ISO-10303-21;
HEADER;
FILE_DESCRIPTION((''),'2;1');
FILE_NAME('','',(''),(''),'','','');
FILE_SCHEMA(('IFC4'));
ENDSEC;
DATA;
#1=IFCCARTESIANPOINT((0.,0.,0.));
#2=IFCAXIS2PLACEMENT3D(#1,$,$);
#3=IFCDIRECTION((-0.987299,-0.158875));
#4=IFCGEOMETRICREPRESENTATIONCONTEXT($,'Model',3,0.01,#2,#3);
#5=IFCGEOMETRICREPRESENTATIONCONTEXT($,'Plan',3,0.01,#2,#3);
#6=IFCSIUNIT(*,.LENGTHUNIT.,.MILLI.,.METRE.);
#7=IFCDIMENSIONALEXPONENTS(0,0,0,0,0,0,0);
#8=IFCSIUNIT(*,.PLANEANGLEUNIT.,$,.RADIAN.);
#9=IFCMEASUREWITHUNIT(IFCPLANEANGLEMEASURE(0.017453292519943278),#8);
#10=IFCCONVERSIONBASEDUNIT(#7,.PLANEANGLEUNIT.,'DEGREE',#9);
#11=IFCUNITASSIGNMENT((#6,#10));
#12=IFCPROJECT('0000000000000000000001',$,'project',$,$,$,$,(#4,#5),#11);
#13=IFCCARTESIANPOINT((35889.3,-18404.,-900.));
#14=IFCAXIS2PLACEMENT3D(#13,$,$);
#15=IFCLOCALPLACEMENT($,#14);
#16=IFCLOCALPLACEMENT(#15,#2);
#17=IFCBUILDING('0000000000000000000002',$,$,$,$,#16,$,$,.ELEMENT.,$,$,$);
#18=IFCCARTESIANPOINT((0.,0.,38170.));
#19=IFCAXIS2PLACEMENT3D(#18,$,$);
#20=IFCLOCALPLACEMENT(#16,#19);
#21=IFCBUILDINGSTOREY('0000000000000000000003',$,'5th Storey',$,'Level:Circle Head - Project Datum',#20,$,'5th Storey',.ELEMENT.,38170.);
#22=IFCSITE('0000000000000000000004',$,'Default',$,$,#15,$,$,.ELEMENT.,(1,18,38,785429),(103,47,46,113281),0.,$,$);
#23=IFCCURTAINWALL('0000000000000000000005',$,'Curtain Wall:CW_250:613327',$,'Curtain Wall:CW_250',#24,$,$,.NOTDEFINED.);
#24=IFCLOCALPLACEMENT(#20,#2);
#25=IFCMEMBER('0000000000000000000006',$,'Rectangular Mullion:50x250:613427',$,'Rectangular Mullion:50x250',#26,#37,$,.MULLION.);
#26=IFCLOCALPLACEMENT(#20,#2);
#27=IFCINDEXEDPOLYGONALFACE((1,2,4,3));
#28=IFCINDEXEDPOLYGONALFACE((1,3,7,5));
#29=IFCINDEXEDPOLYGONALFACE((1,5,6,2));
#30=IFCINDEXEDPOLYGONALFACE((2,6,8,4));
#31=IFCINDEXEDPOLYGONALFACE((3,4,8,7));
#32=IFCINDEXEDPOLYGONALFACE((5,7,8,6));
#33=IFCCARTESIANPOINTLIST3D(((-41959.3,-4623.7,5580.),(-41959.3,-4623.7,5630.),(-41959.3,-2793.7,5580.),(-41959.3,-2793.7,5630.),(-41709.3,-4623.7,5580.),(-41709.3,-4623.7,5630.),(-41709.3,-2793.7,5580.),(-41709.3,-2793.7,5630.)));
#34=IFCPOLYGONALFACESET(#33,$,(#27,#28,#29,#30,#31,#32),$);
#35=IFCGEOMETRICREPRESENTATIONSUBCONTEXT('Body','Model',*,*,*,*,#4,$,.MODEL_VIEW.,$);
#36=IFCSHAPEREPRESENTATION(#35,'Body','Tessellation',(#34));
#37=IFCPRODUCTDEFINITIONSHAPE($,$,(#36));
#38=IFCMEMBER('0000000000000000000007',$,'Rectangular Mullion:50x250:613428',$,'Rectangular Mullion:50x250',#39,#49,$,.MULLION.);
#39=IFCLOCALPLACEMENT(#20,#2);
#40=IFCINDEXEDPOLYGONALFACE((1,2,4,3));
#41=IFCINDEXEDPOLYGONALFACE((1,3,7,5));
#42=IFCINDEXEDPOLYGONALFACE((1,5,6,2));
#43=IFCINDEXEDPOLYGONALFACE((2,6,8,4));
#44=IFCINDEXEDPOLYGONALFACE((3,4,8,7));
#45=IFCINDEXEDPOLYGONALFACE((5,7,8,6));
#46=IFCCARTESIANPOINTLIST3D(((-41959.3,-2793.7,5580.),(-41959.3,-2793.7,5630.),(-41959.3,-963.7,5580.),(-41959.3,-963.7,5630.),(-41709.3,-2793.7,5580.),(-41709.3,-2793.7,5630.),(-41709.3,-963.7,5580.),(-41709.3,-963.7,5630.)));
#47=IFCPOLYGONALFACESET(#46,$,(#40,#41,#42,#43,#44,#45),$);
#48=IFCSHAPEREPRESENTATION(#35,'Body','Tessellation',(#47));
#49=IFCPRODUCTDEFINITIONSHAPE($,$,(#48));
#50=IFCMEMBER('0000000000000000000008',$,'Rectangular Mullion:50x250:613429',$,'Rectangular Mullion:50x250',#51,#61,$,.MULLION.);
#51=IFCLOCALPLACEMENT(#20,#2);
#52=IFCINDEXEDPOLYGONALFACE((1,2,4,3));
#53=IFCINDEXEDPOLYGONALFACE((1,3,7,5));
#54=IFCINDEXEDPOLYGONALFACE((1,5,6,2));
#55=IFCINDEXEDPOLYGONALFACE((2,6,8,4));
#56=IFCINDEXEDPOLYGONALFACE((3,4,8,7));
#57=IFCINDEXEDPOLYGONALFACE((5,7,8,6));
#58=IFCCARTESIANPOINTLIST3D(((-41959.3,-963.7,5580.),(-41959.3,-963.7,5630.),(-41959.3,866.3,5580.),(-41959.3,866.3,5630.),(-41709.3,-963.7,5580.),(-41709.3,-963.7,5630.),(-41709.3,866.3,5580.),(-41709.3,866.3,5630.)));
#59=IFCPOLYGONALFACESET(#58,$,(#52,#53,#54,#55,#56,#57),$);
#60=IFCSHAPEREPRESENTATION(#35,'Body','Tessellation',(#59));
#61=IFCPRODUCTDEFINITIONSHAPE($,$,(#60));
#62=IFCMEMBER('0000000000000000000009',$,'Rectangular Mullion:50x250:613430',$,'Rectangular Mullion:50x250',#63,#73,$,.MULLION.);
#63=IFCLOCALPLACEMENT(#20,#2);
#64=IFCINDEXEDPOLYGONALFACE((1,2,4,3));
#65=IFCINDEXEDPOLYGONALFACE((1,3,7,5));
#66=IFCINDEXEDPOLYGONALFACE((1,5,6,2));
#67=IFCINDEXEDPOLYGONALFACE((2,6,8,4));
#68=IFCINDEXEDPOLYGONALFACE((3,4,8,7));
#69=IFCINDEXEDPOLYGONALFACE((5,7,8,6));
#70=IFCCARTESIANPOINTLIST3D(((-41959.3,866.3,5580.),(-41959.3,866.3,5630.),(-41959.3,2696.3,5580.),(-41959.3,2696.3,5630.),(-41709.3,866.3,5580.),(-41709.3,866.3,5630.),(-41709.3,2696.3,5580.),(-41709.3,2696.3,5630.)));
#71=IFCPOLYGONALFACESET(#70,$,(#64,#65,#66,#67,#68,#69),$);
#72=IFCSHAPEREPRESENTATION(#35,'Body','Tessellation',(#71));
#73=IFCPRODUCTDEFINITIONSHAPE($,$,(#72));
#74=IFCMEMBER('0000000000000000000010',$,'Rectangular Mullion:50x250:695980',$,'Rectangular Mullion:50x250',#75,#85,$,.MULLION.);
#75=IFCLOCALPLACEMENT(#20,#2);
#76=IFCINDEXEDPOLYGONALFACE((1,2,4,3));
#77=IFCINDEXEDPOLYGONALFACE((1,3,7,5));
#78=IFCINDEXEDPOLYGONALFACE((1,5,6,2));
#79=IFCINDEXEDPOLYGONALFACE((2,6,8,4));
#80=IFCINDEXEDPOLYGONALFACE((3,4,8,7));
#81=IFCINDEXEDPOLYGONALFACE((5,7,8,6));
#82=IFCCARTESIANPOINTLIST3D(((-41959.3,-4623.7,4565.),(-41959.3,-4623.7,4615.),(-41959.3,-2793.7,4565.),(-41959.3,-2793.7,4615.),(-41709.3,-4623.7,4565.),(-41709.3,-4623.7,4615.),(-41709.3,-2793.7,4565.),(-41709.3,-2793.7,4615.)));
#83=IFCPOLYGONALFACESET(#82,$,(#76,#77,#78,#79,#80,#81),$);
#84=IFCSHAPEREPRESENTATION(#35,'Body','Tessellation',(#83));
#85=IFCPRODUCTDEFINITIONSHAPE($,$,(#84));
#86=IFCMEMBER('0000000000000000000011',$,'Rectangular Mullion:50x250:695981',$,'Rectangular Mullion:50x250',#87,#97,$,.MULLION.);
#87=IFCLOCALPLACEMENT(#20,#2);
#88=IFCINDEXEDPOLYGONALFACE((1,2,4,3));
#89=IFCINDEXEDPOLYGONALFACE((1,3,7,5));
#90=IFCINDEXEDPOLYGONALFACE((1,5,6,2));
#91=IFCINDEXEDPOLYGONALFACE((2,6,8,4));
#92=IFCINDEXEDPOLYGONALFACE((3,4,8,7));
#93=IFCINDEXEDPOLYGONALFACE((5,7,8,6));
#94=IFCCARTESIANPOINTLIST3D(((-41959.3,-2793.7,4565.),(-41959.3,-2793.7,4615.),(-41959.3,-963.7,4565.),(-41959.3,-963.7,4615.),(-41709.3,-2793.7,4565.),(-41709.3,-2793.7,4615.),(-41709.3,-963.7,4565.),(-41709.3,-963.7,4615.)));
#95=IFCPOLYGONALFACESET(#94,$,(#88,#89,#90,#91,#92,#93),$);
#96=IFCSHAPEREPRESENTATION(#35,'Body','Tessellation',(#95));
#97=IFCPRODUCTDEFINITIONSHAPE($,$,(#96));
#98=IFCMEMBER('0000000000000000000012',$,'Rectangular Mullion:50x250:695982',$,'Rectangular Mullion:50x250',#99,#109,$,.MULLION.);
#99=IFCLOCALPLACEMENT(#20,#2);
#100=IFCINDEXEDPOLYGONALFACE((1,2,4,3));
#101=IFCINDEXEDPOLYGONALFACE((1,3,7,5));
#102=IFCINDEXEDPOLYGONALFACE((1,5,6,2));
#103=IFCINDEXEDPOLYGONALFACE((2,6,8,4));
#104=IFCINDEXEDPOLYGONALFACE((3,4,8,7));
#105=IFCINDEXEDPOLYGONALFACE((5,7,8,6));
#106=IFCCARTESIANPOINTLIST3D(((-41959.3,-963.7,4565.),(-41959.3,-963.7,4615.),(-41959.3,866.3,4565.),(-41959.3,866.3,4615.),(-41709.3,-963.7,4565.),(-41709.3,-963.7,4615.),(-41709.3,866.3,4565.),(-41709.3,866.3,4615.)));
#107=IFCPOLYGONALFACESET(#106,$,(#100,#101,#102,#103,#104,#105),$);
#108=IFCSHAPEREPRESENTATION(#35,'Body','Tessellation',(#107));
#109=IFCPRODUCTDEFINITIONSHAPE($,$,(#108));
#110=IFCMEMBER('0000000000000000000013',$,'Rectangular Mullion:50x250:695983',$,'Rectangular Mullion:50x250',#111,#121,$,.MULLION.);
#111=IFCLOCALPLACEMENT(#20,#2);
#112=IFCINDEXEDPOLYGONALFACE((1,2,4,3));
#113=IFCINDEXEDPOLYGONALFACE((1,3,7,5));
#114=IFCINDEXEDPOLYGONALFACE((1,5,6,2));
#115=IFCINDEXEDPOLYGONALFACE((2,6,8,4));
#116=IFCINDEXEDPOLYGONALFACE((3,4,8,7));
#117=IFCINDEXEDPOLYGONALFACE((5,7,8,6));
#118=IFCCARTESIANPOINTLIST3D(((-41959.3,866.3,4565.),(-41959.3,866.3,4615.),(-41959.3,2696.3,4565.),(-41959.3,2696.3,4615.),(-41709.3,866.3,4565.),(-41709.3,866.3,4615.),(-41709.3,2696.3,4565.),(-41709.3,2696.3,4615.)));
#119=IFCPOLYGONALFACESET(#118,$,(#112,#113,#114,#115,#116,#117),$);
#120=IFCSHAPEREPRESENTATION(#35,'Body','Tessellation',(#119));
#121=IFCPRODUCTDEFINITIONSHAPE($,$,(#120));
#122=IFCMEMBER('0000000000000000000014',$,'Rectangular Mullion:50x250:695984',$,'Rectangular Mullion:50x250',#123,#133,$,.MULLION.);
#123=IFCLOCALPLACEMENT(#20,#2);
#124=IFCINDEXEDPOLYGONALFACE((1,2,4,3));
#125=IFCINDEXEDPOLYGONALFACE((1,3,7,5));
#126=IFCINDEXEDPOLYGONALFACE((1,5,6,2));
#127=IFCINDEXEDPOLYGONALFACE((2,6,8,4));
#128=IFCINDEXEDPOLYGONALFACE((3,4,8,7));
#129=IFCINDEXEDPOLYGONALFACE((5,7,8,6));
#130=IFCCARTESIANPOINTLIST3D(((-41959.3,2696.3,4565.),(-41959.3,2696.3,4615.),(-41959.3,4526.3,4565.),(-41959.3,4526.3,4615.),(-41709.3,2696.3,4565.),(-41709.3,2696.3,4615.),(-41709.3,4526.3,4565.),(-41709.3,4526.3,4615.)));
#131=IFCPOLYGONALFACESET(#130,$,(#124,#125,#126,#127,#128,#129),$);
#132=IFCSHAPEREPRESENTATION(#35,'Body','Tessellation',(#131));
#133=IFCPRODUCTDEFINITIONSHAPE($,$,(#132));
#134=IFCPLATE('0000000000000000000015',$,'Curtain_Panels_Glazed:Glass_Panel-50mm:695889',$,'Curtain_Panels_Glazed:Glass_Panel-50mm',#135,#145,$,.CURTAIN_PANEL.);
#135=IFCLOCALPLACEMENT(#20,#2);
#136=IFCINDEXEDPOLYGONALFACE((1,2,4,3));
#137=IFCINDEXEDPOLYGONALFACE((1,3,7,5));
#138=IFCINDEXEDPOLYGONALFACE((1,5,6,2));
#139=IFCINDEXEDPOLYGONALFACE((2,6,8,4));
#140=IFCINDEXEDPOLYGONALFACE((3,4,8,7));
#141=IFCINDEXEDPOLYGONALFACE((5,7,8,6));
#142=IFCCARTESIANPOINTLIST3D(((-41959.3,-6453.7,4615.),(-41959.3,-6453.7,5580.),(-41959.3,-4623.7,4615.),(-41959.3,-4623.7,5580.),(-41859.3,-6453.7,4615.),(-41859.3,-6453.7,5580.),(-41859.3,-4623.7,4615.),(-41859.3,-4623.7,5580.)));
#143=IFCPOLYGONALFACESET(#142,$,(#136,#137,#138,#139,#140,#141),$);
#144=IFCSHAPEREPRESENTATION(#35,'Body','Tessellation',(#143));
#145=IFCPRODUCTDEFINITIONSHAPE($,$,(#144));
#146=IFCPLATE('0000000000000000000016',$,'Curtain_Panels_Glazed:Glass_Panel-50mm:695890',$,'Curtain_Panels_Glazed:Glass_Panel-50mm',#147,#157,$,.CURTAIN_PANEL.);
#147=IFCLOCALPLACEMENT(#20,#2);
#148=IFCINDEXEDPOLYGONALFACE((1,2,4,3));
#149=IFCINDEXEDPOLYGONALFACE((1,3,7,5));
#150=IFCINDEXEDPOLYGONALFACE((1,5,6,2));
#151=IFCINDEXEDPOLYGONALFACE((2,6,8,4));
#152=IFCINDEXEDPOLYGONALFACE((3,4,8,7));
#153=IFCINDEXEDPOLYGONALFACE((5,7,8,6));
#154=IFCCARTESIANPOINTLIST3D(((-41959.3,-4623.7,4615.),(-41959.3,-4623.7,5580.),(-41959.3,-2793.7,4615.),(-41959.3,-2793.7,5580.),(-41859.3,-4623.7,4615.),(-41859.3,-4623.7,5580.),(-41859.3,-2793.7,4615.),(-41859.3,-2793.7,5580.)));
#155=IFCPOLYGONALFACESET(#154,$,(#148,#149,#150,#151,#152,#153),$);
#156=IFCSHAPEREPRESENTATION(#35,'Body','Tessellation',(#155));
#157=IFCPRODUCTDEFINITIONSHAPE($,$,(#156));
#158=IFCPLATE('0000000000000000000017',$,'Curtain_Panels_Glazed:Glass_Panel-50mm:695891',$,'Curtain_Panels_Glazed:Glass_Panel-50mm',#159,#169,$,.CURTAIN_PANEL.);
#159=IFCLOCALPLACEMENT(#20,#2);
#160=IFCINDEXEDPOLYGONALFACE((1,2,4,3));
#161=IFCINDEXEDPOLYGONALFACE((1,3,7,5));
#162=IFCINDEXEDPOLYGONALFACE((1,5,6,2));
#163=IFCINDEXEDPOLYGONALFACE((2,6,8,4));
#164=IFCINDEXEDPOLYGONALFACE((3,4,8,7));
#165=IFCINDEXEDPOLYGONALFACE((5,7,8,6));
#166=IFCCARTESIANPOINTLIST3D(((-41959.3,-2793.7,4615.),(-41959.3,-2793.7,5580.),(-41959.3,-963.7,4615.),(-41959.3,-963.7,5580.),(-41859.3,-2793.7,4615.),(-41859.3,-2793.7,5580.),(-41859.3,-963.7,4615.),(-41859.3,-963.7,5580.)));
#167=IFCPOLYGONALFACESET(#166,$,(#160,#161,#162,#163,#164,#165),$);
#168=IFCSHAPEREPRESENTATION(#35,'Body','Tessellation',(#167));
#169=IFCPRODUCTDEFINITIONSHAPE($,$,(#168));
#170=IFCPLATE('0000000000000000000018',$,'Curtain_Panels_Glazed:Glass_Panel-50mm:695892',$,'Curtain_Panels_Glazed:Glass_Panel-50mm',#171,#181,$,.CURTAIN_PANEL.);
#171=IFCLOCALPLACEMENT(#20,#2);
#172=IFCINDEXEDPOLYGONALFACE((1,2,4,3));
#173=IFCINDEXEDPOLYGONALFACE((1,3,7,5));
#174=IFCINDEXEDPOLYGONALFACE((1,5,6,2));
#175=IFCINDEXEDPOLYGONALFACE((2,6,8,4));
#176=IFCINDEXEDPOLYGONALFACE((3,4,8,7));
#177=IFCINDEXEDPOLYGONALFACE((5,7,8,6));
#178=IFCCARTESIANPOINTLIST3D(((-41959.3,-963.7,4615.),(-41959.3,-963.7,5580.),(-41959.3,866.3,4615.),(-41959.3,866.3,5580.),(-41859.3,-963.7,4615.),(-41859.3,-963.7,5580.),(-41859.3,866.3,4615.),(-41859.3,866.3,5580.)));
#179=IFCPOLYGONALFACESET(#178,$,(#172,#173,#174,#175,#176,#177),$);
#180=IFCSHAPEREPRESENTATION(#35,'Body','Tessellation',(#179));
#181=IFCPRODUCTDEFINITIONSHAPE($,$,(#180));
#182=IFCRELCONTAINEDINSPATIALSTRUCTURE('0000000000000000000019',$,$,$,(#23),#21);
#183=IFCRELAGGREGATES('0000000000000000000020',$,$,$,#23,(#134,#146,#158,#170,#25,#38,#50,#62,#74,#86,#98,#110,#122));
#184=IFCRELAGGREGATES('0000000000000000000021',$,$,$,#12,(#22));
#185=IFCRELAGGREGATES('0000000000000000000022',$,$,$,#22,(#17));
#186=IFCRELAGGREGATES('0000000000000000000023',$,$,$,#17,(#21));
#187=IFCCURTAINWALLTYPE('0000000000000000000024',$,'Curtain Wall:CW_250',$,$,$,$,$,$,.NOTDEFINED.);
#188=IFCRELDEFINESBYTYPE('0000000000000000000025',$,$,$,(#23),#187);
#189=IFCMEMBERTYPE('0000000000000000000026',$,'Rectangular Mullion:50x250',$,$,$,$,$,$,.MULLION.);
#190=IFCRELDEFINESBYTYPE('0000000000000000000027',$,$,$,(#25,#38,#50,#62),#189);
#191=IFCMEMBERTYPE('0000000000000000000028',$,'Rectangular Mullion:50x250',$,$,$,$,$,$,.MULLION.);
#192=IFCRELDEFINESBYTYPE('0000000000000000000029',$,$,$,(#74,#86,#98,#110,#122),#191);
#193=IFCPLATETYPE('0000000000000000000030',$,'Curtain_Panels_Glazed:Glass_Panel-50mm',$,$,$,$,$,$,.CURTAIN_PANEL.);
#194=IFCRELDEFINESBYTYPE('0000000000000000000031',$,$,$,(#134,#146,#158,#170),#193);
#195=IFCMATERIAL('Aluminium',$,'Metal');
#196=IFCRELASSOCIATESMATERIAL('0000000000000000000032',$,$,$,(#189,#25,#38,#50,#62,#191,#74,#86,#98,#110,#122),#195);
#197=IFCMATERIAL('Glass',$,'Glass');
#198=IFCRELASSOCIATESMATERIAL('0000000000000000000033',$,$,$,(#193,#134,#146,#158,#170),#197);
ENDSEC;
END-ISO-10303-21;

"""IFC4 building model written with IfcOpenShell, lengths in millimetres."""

from ifc_helpers import new_model, entity, si_unit, converted_unit, direction, frame, origin, place, context, subcontext, project, spatial, indexed_curve, outline, extrude, source, transform, mapped, material, type_object, type_shapes, element, aggregate, save


model = new_model("IFC4")

# Units and contexts
model_context = context("Model", 3, precision=0.01, world=origin(), true_north=direction((-0.987299, -0.158875)))
plan_context = context("Plan", 3, precision=0.01, world=origin(), true_north=direction((-0.987299, -0.158875)))
body_context = subcontext(model_context, "Body", "Model", "MODEL_VIEW")
ifc_project = project(units=[si_unit("LENGTHUNIT", "METRE", prefix="MILLI"), converted_unit("PLANEANGLEUNIT", "DEGREE", entity("IfcPlaneAngleMeasure", 0.017453292519943278), si_unit("PLANEANGLEUNIT", "RADIAN"), dimensions=[0, 0, 0, 0, 0, 0, 0])], contexts=[model_context, plan_context])

# Site, building, storey
site_placement = place(None, frame((35889.3, -18404.0, -900.0)))
site = spatial("IfcSite", under=ifc_project, at=site_placement, Name="Default", CompositionType="ELEMENT", RefLatitude=(1, 18, 38, 785429), RefLongitude=(103, 47, 46, 113281), RefElevation=0.0)
building_placement = place(site_placement, origin())
building = spatial("IfcBuilding", under=site, at=building_placement, CompositionType="ELEMENT")
storey_placement = place(building_placement, frame((0.0, 0.0, 38170.0)))
storey = spatial("IfcBuildingStorey", under=building, at=storey_placement, Name="5th Storey", ObjectType="Level:Circle Head - Project Datum", LongName="5th Storey", CompositionType="ELEMENT", Elevation=38170.0)

# Curtain wall, members
curtain_wall_type = type_object("IfcCurtainWallType", Name="Curtain Wall:CW_250", PredefinedType="NOTDEFINED")
curtain_wall_1_placement = place(storey_placement, frame((0.0, 0.0, -38170.0)))
curtain_wall_1 = element("IfcCurtainWall", 1, at=curtain_wall_1_placement, inside=storey, type_object=curtain_wall_type, Name="Curtain Wall:CW_250:613327", ObjectType="Curtain Wall:CW_250", PredefinedType="NOTDEFINED")
ifc_material_1 = material(Name="Aluminium", Category="Metal")
member_type_1 = type_object("IfcMemberType", Name="Rectangular Mullion:50x250", PredefinedType="MULLION", material=ifc_material_1)
shared_shape_1 = source(origin(), body_context, "Body", "SweptSolid", [
    extrude(outline(indexed_curve([(-25.0, -125.0), (25.0, -125.0), (25.0, 125.0), (-25.0, 125.0), (-25.0, -125.0)], self_intersect=False)), frame((-25.0, -125.0, -1830.0), z_axis=(0.0, 0.0, 1.0), x_axis=(-1.0, 0.0, 0.0)), (0.0, 0.0, 1.0), 1830.0),
])
type_shapes(member_type_1, [shared_shape_1])
member_1_placement = place(curtain_wall_1_placement, frame((-41709.3, -2793.7, 43800.0), z_axis=(0.0, 1.0, 0.0), x_axis=(0.0, 0.0, 1.0)))
member_1 = element("IfcMember", 2, at=member_1_placement, type_object=member_type_1, material=ifc_material_1, Name="Rectangular Mullion:50x250:613427", ObjectType="Rectangular Mullion:50x250", PredefinedType="MULLION", context=body_context, shape_type="MappedRepresentation", body=[
    mapped(shared_shape_1, transform((0.0, 0.0, 0.0), scale=1.0)),
])
member_2_placement = place(curtain_wall_1_placement, frame((-41709.3, -963.7, 43800.0), z_axis=(0.0, 1.0, 0.0), x_axis=(0.0, 0.0, 1.0)))
member_2 = element("IfcMember", 3, at=member_2_placement, type_object=member_type_1, material=ifc_material_1, Name="Rectangular Mullion:50x250:613428", ObjectType="Rectangular Mullion:50x250", PredefinedType="MULLION", context=body_context, shape_type="MappedRepresentation", body=[
    mapped(shared_shape_1, transform((0.0, 0.0, 0.0), scale=1.0)),
])
member_3_placement = place(curtain_wall_1_placement, frame((-41709.3, 866.3, 43800.0), z_axis=(0.0, 1.0, 0.0), x_axis=(0.0, 0.0, 1.0)))
member_3 = element("IfcMember", 4, at=member_3_placement, type_object=member_type_1, material=ifc_material_1, Name="Rectangular Mullion:50x250:613429", ObjectType="Rectangular Mullion:50x250", PredefinedType="MULLION", context=body_context, shape_type="MappedRepresentation", body=[
    mapped(shared_shape_1, transform((0.0, 0.0, 0.0), scale=1.0)),
])
member_4_placement = place(curtain_wall_1_placement, frame((-41709.3, 2696.3, 43800.0), z_axis=(0.0, 1.0, 0.0), x_axis=(0.0, 0.0, 1.0)))
member_4 = element("IfcMember", 5, at=member_4_placement, type_object=member_type_1, material=ifc_material_1, Name="Rectangular Mullion:50x250:613430", ObjectType="Rectangular Mullion:50x250", PredefinedType="MULLION", context=body_context, shape_type="MappedRepresentation", body=[
    mapped(shared_shape_1, transform((0.0, 0.0, 0.0), scale=1.0)),
])

# Members
member_type_2 = type_object("IfcMemberType", Name="Rectangular Mullion:50x250", PredefinedType="MULLION", material=ifc_material_1)
shared_shape_2 = source(origin(), body_context, "Body", "SweptSolid", [
    extrude(outline(indexed_curve([(-25.0, -125.0), (25.0, -125.0), (25.0, 125.0), (-25.0, 125.0), (-25.0, -125.0)], self_intersect=False)), frame((0.0, -125.0, -1830.0), z_axis=(0.0, 0.0, 1.0), x_axis=(-1.0, 0.0, 0.0)), (0.0, 0.0, 1.0), 1830.0),
])
type_shapes(member_type_2, [shared_shape_2])
member_5_placement = place(curtain_wall_1_placement, frame((-41709.3, -2793.7, 42760.0), z_axis=(0.0, 1.0, 0.0), x_axis=(0.0, 0.0, 1.0)))
member_5 = element("IfcMember", 6, at=member_5_placement, type_object=member_type_2, material=ifc_material_1, Name="Rectangular Mullion:50x250:695980", ObjectType="Rectangular Mullion:50x250", PredefinedType="MULLION", context=body_context, shape_type="MappedRepresentation", body=[
    mapped(shared_shape_2, transform((0.0, 0.0, 0.0), scale=1.0)),
])
member_6_placement = place(curtain_wall_1_placement, frame((-41709.3, -963.7, 42760.0), z_axis=(0.0, 1.0, 0.0), x_axis=(0.0, 0.0, 1.0)))
member_6 = element("IfcMember", 7, at=member_6_placement, type_object=member_type_2, material=ifc_material_1, Name="Rectangular Mullion:50x250:695981", ObjectType="Rectangular Mullion:50x250", PredefinedType="MULLION", context=body_context, shape_type="MappedRepresentation", body=[
    mapped(shared_shape_2, transform((0.0, 0.0, 0.0), scale=1.0)),
])
member_7_placement = place(curtain_wall_1_placement, frame((-41709.3, 866.3, 42760.0), z_axis=(0.0, 1.0, 0.0), x_axis=(0.0, 0.0, 1.0)))
member_7 = element("IfcMember", 8, at=member_7_placement, type_object=member_type_2, material=ifc_material_1, Name="Rectangular Mullion:50x250:695982", ObjectType="Rectangular Mullion:50x250", PredefinedType="MULLION", context=body_context, shape_type="MappedRepresentation", body=[
    mapped(shared_shape_2, transform((0.0, 0.0, 0.0), scale=1.0)),
])
member_8_placement = place(curtain_wall_1_placement, frame((-41709.3, 2696.3, 42760.0), z_axis=(0.0, 1.0, 0.0), x_axis=(0.0, 0.0, 1.0)))
member_8 = element("IfcMember", 9, at=member_8_placement, type_object=member_type_2, material=ifc_material_1, Name="Rectangular Mullion:50x250:695983", ObjectType="Rectangular Mullion:50x250", PredefinedType="MULLION", context=body_context, shape_type="MappedRepresentation", body=[
    mapped(shared_shape_2, transform((0.0, 0.0, 0.0), scale=1.0)),
])
member_9_placement = place(curtain_wall_1_placement, frame((-41709.3, 4526.3, 42760.0), z_axis=(0.0, 1.0, 0.0), x_axis=(0.0, 0.0, 1.0)))
member_9 = element("IfcMember", 10, at=member_9_placement, type_object=member_type_2, material=ifc_material_1, Name="Rectangular Mullion:50x250:695984", ObjectType="Rectangular Mullion:50x250", PredefinedType="MULLION", context=body_context, shape_type="MappedRepresentation", body=[
    mapped(shared_shape_2, transform((0.0, 0.0, 0.0), scale=1.0)),
])

# Plates
ifc_material_2 = material(Name="Glass", Category="Glass")
plate_type_1 = type_object("IfcPlateType", Name="Curtain_Panels_Glazed:Glass_Panel-50mm", PredefinedType="CURTAIN_PANEL", material=ifc_material_2)
shared_shape_3 = source(origin(), body_context, "Body", "SweptSolid", [
    extrude(outline(indexed_curve([(-50.0, -915.0), (50.0, -915.0), (50.0, 915.0), (-50.0, 915.0), (-50.0, -915.0)], self_intersect=False)), frame((0.0, 200.0, 0.0), z_axis=(0.0, 0.0, 1.0), x_axis=(0.0, 1.0, 0.0)), (0.0, 0.0, 1.0), 965.0),
])
type_shapes(plate_type_1, [shared_shape_3])
plate_1_placement = place(curtain_wall_1_placement, frame((-41709.3, -5538.7, 42785.0), z_axis=(0.0, 0.0, 1.0), x_axis=(0.0, 1.0, 0.0)))
plate_1 = element("IfcPlate", 11, at=plate_1_placement, type_object=plate_type_1, material=ifc_material_2, Name="Curtain_Panels_Glazed:Glass_Panel-50mm:695889", ObjectType="Curtain_Panels_Glazed:Glass_Panel-50mm", PredefinedType="CURTAIN_PANEL", context=body_context, shape_type="MappedRepresentation", body=[
    mapped(shared_shape_3, transform((0.0, 0.0, 0.0), scale=1.0)),
])
plate_2_placement = place(curtain_wall_1_placement, frame((-41709.3, -3708.7, 42785.0), z_axis=(0.0, 0.0, 1.0), x_axis=(0.0, 1.0, 0.0)))
plate_2 = element("IfcPlate", 12, at=plate_2_placement, type_object=plate_type_1, material=ifc_material_2, Name="Curtain_Panels_Glazed:Glass_Panel-50mm:695890", ObjectType="Curtain_Panels_Glazed:Glass_Panel-50mm", PredefinedType="CURTAIN_PANEL", context=body_context, shape_type="MappedRepresentation", body=[
    mapped(shared_shape_3, transform((0.0, 0.0, 0.0), scale=1.0)),
])
plate_3_placement = place(curtain_wall_1_placement, frame((-41709.3, -1878.7, 42785.0), z_axis=(0.0, 0.0, 1.0), x_axis=(0.0, 1.0, 0.0)))
plate_3 = element("IfcPlate", 13, at=plate_3_placement, type_object=plate_type_1, material=ifc_material_2, Name="Curtain_Panels_Glazed:Glass_Panel-50mm:695891", ObjectType="Curtain_Panels_Glazed:Glass_Panel-50mm", PredefinedType="CURTAIN_PANEL", context=body_context, shape_type="MappedRepresentation", body=[
    mapped(shared_shape_3, transform((0.0, 0.0, 0.0), scale=1.0)),
])
plate_4_placement = place(curtain_wall_1_placement, frame((-41709.3, -48.7, 42785.0), z_axis=(0.0, 0.0, 1.0), x_axis=(0.0, 1.0, 0.0)))
plate_4 = element("IfcPlate", 14, at=plate_4_placement, type_object=plate_type_1, material=ifc_material_2, Name="Curtain_Panels_Glazed:Glass_Panel-50mm:695892", ObjectType="Curtain_Panels_Glazed:Glass_Panel-50mm", PredefinedType="CURTAIN_PANEL", context=body_context, shape_type="MappedRepresentation", body=[
    mapped(shared_shape_3, transform((0.0, 0.0, 0.0), scale=1.0)),
])
aggregate(curtain_wall_1, [plate_1, plate_2, plate_3, plate_4, member_1, member_2, member_3, member_4, member_5, member_6, member_7, member_8, member_9])

save(model, "model.ifc")
